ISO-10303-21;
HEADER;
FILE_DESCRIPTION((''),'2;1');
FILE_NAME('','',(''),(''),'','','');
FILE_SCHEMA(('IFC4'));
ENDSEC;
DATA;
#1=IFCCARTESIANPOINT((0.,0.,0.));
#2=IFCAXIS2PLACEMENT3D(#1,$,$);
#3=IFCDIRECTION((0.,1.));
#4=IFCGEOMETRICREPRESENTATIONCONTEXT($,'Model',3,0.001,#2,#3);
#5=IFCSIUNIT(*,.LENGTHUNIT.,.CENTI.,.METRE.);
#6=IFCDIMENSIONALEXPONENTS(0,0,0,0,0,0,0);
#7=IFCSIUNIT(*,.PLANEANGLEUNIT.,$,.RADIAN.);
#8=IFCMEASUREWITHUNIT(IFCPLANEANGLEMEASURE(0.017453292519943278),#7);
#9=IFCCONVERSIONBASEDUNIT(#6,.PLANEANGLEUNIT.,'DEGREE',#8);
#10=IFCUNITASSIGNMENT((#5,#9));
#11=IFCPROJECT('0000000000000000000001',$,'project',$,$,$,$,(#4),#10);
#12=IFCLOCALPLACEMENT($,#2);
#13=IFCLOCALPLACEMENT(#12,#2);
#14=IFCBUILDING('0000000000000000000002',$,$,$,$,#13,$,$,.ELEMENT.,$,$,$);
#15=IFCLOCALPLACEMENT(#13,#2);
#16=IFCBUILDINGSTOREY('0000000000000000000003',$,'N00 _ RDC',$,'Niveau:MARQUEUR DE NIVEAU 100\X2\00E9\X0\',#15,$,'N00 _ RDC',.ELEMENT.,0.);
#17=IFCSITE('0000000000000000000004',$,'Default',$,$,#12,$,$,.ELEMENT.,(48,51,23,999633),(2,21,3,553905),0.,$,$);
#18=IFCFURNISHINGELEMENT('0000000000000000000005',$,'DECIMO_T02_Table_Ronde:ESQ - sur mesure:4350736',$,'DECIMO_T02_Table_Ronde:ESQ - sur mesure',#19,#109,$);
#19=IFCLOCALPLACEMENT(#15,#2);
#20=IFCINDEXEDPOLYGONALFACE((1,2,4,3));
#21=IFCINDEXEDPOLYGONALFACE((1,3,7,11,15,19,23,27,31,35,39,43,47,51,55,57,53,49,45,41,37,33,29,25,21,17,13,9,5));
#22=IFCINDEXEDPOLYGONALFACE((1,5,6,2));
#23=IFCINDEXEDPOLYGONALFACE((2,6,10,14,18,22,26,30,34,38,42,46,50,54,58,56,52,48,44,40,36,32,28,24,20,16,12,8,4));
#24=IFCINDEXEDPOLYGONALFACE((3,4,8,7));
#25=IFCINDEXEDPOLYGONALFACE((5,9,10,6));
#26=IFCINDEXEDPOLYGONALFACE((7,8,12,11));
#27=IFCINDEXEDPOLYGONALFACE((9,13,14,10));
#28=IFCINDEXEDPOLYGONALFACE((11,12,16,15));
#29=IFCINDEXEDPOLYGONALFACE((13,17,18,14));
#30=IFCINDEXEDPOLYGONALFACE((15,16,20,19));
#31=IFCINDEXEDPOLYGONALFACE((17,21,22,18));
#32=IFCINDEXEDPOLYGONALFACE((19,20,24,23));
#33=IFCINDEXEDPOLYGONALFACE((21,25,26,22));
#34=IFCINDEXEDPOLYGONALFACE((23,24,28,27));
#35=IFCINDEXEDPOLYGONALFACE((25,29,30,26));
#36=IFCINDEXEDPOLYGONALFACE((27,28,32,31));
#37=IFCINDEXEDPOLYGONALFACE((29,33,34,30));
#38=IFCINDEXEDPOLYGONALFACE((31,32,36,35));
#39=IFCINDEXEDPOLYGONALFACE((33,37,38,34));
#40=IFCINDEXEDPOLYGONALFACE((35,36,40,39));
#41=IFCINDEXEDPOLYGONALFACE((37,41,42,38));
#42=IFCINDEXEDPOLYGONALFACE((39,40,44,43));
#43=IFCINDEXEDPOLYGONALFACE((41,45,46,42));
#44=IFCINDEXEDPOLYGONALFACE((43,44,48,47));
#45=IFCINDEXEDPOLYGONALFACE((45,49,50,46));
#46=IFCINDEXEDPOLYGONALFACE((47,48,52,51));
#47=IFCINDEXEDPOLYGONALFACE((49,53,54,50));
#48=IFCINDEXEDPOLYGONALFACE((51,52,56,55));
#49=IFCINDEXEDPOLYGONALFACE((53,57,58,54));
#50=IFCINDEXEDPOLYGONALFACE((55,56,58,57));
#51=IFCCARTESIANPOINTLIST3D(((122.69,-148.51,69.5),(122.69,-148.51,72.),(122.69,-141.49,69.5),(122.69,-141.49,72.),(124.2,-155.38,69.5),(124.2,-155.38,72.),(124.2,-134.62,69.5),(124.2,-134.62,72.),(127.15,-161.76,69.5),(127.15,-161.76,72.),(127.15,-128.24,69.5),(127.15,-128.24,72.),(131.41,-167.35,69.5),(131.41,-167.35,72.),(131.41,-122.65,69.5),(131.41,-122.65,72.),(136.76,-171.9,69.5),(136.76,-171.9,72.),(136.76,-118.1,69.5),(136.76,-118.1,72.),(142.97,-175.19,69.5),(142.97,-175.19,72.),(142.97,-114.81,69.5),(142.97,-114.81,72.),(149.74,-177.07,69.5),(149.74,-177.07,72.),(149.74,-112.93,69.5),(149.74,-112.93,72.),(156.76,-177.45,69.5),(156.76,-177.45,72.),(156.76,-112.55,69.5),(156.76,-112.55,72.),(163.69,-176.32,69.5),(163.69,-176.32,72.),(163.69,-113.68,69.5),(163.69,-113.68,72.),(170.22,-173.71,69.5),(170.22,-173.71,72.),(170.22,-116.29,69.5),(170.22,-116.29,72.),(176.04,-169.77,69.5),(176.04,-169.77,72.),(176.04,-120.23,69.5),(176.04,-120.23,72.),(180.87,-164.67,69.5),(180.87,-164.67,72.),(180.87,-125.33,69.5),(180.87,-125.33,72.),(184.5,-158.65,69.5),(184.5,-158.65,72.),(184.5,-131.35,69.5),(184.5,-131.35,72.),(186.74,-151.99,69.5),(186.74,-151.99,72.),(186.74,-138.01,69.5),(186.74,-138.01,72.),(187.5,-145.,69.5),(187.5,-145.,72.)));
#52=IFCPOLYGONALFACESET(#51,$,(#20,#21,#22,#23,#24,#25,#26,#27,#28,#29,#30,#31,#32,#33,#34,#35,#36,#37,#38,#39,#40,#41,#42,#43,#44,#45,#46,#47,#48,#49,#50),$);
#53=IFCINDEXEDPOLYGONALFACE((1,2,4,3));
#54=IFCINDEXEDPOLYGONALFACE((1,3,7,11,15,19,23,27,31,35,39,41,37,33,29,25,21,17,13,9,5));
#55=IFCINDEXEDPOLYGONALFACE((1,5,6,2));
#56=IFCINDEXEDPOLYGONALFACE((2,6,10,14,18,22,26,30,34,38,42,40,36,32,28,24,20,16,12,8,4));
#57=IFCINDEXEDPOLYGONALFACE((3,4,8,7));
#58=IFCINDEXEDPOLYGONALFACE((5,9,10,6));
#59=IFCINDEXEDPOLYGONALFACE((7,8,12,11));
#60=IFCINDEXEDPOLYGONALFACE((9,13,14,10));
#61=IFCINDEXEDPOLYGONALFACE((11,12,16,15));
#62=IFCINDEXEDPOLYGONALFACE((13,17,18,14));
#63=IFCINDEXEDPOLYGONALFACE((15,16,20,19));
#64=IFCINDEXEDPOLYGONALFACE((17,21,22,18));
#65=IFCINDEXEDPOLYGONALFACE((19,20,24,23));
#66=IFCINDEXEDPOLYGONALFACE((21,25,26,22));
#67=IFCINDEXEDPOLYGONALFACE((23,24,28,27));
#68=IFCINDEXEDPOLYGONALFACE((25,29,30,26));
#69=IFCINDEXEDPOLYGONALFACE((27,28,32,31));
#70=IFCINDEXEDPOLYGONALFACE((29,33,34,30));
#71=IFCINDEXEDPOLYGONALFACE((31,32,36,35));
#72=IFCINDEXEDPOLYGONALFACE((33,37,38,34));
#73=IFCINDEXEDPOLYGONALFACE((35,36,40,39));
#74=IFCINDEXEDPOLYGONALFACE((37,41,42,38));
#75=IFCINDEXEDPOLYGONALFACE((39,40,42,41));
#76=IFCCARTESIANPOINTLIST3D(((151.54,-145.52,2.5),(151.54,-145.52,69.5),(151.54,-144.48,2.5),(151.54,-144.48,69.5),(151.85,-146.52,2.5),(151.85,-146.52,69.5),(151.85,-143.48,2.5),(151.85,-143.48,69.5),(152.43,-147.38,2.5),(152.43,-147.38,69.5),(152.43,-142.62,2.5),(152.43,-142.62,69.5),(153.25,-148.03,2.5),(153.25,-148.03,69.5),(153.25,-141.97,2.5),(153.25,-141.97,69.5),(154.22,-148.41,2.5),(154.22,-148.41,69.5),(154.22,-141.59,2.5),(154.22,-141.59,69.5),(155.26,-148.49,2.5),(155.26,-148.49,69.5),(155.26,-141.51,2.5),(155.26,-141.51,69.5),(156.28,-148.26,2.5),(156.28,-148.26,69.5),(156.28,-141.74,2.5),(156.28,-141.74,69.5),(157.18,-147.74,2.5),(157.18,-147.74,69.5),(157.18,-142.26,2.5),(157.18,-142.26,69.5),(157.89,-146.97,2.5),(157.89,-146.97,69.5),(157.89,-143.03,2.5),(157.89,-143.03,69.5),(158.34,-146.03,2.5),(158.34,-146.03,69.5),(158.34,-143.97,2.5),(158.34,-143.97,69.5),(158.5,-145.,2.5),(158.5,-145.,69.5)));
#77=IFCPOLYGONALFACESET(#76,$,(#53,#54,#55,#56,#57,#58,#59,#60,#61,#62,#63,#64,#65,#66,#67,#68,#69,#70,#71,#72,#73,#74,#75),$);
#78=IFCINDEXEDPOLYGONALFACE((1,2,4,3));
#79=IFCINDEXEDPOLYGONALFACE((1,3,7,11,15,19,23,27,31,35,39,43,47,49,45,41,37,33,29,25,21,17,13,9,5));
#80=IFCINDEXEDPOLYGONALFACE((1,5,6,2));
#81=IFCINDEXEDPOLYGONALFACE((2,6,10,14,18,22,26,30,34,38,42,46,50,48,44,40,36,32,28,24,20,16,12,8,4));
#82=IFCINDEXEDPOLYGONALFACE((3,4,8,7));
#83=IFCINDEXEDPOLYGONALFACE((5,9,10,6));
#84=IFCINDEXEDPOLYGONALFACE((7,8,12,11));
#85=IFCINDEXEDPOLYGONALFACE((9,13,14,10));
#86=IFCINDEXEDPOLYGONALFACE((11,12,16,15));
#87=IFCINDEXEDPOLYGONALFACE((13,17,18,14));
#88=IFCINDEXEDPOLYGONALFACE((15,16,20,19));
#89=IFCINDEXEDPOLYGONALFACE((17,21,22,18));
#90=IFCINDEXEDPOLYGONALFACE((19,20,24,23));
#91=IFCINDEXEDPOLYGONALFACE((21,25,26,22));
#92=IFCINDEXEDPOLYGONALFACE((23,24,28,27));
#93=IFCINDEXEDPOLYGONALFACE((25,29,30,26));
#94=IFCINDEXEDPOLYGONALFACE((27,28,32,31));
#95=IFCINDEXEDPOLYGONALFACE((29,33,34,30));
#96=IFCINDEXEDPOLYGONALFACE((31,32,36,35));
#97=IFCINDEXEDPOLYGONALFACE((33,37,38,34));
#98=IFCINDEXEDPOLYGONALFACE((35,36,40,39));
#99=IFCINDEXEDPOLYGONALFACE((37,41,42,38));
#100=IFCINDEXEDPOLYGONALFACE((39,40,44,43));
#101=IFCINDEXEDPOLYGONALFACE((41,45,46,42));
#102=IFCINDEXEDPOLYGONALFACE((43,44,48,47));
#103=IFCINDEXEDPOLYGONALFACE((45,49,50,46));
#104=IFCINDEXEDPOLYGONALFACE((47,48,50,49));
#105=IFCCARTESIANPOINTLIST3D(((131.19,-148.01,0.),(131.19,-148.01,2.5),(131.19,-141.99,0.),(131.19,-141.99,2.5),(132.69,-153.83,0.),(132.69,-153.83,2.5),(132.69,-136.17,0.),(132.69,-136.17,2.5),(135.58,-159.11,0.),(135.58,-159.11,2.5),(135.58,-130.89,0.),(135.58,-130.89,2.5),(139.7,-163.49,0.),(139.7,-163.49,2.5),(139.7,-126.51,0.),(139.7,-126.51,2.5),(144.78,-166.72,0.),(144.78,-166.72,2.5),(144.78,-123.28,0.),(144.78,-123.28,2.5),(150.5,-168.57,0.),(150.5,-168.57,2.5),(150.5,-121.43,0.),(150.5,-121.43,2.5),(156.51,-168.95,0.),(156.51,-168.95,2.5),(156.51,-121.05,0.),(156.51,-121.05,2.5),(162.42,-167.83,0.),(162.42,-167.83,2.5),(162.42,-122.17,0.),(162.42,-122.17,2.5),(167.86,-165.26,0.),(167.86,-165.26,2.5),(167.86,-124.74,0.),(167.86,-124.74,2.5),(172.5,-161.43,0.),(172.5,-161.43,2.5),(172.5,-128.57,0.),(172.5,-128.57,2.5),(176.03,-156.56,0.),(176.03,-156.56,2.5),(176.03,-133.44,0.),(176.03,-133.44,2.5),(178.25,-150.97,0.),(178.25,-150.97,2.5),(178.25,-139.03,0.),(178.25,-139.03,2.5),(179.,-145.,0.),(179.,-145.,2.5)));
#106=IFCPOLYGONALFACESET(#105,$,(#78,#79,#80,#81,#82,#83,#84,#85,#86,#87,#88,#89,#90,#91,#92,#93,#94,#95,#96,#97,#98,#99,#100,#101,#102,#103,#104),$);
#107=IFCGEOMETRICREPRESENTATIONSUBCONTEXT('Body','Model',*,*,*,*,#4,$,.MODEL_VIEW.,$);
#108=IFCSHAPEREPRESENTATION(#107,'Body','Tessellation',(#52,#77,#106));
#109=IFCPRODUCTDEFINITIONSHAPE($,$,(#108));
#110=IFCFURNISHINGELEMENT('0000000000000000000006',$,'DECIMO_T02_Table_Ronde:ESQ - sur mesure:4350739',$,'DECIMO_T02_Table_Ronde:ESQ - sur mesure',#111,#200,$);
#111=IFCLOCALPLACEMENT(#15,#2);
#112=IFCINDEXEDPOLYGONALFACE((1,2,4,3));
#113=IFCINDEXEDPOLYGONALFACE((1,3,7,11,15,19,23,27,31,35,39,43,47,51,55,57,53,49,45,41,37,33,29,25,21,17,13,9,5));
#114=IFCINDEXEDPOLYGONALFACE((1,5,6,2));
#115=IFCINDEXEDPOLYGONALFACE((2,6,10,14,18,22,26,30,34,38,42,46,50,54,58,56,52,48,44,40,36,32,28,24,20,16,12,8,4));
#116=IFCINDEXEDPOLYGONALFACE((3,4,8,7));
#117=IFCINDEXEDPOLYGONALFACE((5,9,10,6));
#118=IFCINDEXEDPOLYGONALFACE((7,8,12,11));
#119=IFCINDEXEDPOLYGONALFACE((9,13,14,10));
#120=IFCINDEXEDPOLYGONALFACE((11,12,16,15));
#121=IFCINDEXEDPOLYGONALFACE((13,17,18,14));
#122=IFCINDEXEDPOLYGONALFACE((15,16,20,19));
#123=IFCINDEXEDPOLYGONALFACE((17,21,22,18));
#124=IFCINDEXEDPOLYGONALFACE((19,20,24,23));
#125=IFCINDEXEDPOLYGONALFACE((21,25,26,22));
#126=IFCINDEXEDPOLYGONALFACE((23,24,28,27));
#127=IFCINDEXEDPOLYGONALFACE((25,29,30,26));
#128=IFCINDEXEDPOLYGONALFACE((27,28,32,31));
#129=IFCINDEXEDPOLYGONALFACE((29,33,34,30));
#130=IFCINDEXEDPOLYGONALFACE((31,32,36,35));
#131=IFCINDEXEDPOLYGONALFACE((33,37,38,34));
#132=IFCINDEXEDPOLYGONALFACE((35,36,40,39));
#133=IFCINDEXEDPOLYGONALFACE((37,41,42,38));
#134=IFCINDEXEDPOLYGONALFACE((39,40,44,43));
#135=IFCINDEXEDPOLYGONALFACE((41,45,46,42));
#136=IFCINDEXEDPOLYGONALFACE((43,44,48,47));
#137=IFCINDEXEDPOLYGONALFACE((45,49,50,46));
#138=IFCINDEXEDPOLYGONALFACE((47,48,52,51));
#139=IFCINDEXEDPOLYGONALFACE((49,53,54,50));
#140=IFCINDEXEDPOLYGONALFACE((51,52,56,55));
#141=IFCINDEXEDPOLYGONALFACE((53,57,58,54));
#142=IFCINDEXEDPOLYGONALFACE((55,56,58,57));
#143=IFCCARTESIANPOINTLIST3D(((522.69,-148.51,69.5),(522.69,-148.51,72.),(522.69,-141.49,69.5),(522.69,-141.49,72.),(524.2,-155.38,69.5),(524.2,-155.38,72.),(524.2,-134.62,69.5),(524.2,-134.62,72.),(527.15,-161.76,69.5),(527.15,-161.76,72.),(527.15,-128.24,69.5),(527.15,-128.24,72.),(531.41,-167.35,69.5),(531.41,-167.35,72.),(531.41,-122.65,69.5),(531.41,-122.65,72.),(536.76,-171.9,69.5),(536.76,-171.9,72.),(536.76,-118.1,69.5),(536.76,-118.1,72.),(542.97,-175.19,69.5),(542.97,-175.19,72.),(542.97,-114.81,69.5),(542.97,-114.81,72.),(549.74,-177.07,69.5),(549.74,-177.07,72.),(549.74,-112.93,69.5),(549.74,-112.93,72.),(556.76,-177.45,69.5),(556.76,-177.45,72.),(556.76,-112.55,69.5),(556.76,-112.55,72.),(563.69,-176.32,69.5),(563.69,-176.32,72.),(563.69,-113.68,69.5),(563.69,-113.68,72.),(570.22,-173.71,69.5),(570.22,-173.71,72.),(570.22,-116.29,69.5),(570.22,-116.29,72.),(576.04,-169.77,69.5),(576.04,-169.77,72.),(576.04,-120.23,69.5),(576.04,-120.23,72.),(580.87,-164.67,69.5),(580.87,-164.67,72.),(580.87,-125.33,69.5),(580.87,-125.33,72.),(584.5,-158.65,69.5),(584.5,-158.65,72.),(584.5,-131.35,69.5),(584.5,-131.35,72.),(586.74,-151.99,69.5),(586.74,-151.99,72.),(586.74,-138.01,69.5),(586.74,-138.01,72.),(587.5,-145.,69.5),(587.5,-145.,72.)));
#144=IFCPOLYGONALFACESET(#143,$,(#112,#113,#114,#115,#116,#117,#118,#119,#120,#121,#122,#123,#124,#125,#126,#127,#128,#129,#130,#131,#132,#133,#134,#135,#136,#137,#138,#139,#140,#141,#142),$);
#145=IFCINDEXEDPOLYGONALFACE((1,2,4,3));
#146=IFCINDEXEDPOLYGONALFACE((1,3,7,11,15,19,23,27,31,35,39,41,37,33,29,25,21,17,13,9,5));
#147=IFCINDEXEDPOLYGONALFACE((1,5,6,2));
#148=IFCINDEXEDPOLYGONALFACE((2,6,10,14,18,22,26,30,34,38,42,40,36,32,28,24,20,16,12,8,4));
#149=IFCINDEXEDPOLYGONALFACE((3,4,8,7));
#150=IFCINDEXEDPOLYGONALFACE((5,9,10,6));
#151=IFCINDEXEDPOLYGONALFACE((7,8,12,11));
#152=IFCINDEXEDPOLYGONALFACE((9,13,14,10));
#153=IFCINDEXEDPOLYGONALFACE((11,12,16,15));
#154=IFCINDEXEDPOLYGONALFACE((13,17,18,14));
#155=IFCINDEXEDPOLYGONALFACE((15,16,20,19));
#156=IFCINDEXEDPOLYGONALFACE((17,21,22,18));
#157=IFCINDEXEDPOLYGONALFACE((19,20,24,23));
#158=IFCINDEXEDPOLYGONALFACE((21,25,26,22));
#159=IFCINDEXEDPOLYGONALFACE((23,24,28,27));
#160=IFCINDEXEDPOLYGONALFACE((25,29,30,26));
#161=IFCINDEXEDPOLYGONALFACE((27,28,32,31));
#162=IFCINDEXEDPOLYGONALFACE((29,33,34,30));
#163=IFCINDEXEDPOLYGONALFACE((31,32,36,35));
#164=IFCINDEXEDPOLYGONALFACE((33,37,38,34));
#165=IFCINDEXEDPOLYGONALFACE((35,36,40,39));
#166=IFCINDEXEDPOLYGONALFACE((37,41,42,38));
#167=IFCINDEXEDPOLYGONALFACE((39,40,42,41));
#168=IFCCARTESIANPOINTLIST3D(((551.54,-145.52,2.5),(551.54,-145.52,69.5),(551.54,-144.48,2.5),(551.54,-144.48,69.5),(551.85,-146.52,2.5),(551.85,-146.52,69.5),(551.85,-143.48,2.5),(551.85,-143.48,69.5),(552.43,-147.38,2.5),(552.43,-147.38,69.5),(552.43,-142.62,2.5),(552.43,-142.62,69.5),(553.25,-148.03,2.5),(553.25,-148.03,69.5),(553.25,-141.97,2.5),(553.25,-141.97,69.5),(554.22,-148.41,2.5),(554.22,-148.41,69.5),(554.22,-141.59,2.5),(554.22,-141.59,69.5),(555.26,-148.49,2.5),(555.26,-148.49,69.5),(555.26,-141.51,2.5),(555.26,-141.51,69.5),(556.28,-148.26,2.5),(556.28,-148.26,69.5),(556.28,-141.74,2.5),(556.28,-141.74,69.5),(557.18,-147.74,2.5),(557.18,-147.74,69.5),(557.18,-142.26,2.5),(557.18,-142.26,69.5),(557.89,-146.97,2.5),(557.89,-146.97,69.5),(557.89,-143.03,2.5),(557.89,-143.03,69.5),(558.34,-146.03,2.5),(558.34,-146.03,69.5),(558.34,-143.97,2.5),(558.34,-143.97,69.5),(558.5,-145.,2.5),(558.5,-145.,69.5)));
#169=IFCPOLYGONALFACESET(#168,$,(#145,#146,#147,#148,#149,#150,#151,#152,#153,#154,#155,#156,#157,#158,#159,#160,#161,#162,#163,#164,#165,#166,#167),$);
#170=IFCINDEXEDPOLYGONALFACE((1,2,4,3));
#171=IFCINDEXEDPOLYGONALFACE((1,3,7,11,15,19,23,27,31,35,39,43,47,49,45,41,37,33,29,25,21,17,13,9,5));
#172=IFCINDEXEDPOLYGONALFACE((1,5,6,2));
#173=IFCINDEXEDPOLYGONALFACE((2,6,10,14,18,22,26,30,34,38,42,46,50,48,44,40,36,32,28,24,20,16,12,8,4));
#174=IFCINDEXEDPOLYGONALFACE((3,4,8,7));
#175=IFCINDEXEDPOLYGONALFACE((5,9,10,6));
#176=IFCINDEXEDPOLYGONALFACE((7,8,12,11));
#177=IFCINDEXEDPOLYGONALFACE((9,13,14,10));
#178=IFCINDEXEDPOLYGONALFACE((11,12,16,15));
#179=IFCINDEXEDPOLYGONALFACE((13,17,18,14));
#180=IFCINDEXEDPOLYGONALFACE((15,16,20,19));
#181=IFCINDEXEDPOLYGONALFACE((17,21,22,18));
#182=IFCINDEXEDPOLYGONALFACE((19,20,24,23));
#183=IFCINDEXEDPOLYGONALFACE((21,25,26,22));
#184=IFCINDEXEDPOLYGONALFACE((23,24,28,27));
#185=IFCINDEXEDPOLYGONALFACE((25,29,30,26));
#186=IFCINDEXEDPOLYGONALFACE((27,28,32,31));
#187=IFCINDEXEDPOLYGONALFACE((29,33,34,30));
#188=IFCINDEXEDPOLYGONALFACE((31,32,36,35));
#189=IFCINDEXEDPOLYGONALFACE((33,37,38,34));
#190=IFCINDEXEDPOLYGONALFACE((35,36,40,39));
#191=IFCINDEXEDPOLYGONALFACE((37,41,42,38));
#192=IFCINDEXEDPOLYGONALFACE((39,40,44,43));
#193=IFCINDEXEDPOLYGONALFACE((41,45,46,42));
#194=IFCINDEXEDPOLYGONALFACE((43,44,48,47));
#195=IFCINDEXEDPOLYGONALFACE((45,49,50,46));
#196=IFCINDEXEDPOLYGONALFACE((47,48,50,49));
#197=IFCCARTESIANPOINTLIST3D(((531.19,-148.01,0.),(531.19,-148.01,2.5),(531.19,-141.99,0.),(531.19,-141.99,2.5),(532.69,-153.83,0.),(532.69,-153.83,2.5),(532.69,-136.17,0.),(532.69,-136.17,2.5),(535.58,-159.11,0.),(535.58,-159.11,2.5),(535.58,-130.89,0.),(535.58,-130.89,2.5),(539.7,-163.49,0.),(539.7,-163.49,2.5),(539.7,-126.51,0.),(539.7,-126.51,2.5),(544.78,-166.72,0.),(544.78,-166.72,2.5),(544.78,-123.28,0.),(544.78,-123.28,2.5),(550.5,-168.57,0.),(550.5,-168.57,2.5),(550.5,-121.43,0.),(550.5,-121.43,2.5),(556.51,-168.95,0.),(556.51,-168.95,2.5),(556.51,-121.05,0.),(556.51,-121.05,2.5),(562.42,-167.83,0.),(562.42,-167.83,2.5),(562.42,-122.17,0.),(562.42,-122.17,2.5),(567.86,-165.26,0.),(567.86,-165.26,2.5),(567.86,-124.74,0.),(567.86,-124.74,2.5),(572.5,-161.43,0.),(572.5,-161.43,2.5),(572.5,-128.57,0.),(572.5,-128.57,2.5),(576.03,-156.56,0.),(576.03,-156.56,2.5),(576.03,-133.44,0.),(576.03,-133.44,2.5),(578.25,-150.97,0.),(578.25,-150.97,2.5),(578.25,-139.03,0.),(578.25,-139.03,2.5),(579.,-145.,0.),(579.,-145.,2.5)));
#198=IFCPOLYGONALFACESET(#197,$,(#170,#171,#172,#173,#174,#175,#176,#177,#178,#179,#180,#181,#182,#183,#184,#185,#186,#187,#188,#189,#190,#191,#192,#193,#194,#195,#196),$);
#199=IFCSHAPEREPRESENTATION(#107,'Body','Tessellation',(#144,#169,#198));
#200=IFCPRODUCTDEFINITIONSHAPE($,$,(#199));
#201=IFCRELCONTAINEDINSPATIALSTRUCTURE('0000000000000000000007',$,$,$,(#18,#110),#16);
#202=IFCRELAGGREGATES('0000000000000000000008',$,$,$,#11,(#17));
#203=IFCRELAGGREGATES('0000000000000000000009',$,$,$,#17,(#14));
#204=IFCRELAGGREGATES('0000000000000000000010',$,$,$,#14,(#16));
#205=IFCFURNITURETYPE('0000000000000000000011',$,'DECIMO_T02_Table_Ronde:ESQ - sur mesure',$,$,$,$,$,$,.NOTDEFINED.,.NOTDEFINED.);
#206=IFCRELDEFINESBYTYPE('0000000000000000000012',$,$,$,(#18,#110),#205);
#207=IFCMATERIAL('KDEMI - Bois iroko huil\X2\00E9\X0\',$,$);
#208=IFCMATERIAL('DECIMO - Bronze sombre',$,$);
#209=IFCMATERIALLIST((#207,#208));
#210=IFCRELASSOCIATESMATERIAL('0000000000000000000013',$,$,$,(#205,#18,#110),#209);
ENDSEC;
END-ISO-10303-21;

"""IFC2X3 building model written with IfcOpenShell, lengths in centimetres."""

from ifc_helpers import new_model, entity, si_unit, converted_unit, direction, frame, frame_2d, origin, place, context, subcontext, project, spatial, circle, extrude, source, transform, mapped, material, material_list, type_object, type_shapes, element, save


model = new_model("IFC2X3")

# Units and contexts
model_context = context("Model", 3, precision=0.001, world=origin(), true_north=direction((0.0, 1.0)))
body_context = subcontext(model_context, "Body", "Model", "MODEL_VIEW")
ifc_project = project(units=[si_unit("LENGTHUNIT", "METRE", prefix="CENTI"), converted_unit("PLANEANGLEUNIT", "DEGREE", entity("IfcPlaneAngleMeasure", 0.017453292519943278), si_unit("PLANEANGLEUNIT", "RADIAN"), dimensions=[0, 0, 0, 0, 0, 0, 0])], contexts=[model_context])

# Site, building, storey
site_placement = place(None, origin())
site = spatial("IfcSite", under=ifc_project, at=site_placement, Name="Default", CompositionType="ELEMENT", RefLatitude=(48, 51, 23, 999633), RefLongitude=(2, 21, 3, 553905), RefElevation=0.0)
building_placement = place(site_placement, origin())
building = spatial("IfcBuilding", under=site, at=building_placement, CompositionType="ELEMENT")
storey_placement = place(building_placement, origin())
storey = spatial("IfcBuildingStorey", under=building, at=storey_placement, Name="N00 _ RDC", ObjectType="Niveau:MARQUEUR DE NIVEAU 100é", LongName="N00 _ RDC", CompositionType="ELEMENT", Elevation=0.0)

# Furnishing elements
ifc_material_1 = material(Name="DECIMO - Bronze sombre")
ifc_material_2 = material(Name="KDEMI - Bois iroko huilé")
ifc_material_list_1 = material_list([ifc_material_2, ifc_material_1])
furniture_type_1 = type_object("IfcFurnitureType", Name="DECIMO_T02_Table_Ronde:ESQ - sur mesure", AssemblyPlace="NOTDEFINED", material=ifc_material_list_1)
shared_shape_1 = source(origin(), body_context, "Body", "SweptSolid", [
    extrude(circle(Radius=32.5, at=frame_2d((0.0, 0.0), x_axis=(1.0, 0.0))), frame((0.0, 0.0, 69.5)), (0.0, 0.0, 1.0), 2.5),
    extrude(circle(Radius=3.5, at=frame_2d((0.0, 0.0), x_axis=(1.0, 0.0))), frame((0.0, 0.0, 2.5)), (0.0, 0.0, 1.0), 67.0),
    extrude(circle(Radius=24.0, at=frame_2d((0.0, 0.0), x_axis=(1.0, 0.0))), origin(), (0.0, 0.0, 1.0), 2.5),
])
type_shapes(furniture_type_1, [shared_shape_1])
furnishing_1_placement = place(storey_placement, frame((155.0, -145.0, 0.0)))
element("IfcFurnishingElement", 1, at=furnishing_1_placement, inside=storey, type_object=furniture_type_1, material=ifc_material_list_1, Name="DECIMO_T02_Table_Ronde:ESQ - sur mesure:4350736", ObjectType="DECIMO_T02_Table_Ronde:ESQ - sur mesure", context=body_context, shape_type="MappedRepresentation", body=[
    mapped(shared_shape_1, transform((0.0, 0.0, 0.0), scale=1.0)),
])
furnishing_2_placement = place(storey_placement, frame((555.0, -145.0, 0.0), z_axis=(0.0, 0.0, 1.0), x_axis=(1.0, 0.0, 0.0)))
element("IfcFurnishingElement", 2, at=furnishing_2_placement, inside=storey, type_object=furniture_type_1, material=ifc_material_list_1, Name="DECIMO_T02_Table_Ronde:ESQ - sur mesure:4350739", ObjectType="DECIMO_T02_Table_Ronde:ESQ - sur mesure", context=body_context, shape_type="MappedRepresentation", body=[
    mapped(shared_shape_1, transform((0.0, 0.0, 0.0), scale=1.0)),
])

save(model, "model.ifc")
